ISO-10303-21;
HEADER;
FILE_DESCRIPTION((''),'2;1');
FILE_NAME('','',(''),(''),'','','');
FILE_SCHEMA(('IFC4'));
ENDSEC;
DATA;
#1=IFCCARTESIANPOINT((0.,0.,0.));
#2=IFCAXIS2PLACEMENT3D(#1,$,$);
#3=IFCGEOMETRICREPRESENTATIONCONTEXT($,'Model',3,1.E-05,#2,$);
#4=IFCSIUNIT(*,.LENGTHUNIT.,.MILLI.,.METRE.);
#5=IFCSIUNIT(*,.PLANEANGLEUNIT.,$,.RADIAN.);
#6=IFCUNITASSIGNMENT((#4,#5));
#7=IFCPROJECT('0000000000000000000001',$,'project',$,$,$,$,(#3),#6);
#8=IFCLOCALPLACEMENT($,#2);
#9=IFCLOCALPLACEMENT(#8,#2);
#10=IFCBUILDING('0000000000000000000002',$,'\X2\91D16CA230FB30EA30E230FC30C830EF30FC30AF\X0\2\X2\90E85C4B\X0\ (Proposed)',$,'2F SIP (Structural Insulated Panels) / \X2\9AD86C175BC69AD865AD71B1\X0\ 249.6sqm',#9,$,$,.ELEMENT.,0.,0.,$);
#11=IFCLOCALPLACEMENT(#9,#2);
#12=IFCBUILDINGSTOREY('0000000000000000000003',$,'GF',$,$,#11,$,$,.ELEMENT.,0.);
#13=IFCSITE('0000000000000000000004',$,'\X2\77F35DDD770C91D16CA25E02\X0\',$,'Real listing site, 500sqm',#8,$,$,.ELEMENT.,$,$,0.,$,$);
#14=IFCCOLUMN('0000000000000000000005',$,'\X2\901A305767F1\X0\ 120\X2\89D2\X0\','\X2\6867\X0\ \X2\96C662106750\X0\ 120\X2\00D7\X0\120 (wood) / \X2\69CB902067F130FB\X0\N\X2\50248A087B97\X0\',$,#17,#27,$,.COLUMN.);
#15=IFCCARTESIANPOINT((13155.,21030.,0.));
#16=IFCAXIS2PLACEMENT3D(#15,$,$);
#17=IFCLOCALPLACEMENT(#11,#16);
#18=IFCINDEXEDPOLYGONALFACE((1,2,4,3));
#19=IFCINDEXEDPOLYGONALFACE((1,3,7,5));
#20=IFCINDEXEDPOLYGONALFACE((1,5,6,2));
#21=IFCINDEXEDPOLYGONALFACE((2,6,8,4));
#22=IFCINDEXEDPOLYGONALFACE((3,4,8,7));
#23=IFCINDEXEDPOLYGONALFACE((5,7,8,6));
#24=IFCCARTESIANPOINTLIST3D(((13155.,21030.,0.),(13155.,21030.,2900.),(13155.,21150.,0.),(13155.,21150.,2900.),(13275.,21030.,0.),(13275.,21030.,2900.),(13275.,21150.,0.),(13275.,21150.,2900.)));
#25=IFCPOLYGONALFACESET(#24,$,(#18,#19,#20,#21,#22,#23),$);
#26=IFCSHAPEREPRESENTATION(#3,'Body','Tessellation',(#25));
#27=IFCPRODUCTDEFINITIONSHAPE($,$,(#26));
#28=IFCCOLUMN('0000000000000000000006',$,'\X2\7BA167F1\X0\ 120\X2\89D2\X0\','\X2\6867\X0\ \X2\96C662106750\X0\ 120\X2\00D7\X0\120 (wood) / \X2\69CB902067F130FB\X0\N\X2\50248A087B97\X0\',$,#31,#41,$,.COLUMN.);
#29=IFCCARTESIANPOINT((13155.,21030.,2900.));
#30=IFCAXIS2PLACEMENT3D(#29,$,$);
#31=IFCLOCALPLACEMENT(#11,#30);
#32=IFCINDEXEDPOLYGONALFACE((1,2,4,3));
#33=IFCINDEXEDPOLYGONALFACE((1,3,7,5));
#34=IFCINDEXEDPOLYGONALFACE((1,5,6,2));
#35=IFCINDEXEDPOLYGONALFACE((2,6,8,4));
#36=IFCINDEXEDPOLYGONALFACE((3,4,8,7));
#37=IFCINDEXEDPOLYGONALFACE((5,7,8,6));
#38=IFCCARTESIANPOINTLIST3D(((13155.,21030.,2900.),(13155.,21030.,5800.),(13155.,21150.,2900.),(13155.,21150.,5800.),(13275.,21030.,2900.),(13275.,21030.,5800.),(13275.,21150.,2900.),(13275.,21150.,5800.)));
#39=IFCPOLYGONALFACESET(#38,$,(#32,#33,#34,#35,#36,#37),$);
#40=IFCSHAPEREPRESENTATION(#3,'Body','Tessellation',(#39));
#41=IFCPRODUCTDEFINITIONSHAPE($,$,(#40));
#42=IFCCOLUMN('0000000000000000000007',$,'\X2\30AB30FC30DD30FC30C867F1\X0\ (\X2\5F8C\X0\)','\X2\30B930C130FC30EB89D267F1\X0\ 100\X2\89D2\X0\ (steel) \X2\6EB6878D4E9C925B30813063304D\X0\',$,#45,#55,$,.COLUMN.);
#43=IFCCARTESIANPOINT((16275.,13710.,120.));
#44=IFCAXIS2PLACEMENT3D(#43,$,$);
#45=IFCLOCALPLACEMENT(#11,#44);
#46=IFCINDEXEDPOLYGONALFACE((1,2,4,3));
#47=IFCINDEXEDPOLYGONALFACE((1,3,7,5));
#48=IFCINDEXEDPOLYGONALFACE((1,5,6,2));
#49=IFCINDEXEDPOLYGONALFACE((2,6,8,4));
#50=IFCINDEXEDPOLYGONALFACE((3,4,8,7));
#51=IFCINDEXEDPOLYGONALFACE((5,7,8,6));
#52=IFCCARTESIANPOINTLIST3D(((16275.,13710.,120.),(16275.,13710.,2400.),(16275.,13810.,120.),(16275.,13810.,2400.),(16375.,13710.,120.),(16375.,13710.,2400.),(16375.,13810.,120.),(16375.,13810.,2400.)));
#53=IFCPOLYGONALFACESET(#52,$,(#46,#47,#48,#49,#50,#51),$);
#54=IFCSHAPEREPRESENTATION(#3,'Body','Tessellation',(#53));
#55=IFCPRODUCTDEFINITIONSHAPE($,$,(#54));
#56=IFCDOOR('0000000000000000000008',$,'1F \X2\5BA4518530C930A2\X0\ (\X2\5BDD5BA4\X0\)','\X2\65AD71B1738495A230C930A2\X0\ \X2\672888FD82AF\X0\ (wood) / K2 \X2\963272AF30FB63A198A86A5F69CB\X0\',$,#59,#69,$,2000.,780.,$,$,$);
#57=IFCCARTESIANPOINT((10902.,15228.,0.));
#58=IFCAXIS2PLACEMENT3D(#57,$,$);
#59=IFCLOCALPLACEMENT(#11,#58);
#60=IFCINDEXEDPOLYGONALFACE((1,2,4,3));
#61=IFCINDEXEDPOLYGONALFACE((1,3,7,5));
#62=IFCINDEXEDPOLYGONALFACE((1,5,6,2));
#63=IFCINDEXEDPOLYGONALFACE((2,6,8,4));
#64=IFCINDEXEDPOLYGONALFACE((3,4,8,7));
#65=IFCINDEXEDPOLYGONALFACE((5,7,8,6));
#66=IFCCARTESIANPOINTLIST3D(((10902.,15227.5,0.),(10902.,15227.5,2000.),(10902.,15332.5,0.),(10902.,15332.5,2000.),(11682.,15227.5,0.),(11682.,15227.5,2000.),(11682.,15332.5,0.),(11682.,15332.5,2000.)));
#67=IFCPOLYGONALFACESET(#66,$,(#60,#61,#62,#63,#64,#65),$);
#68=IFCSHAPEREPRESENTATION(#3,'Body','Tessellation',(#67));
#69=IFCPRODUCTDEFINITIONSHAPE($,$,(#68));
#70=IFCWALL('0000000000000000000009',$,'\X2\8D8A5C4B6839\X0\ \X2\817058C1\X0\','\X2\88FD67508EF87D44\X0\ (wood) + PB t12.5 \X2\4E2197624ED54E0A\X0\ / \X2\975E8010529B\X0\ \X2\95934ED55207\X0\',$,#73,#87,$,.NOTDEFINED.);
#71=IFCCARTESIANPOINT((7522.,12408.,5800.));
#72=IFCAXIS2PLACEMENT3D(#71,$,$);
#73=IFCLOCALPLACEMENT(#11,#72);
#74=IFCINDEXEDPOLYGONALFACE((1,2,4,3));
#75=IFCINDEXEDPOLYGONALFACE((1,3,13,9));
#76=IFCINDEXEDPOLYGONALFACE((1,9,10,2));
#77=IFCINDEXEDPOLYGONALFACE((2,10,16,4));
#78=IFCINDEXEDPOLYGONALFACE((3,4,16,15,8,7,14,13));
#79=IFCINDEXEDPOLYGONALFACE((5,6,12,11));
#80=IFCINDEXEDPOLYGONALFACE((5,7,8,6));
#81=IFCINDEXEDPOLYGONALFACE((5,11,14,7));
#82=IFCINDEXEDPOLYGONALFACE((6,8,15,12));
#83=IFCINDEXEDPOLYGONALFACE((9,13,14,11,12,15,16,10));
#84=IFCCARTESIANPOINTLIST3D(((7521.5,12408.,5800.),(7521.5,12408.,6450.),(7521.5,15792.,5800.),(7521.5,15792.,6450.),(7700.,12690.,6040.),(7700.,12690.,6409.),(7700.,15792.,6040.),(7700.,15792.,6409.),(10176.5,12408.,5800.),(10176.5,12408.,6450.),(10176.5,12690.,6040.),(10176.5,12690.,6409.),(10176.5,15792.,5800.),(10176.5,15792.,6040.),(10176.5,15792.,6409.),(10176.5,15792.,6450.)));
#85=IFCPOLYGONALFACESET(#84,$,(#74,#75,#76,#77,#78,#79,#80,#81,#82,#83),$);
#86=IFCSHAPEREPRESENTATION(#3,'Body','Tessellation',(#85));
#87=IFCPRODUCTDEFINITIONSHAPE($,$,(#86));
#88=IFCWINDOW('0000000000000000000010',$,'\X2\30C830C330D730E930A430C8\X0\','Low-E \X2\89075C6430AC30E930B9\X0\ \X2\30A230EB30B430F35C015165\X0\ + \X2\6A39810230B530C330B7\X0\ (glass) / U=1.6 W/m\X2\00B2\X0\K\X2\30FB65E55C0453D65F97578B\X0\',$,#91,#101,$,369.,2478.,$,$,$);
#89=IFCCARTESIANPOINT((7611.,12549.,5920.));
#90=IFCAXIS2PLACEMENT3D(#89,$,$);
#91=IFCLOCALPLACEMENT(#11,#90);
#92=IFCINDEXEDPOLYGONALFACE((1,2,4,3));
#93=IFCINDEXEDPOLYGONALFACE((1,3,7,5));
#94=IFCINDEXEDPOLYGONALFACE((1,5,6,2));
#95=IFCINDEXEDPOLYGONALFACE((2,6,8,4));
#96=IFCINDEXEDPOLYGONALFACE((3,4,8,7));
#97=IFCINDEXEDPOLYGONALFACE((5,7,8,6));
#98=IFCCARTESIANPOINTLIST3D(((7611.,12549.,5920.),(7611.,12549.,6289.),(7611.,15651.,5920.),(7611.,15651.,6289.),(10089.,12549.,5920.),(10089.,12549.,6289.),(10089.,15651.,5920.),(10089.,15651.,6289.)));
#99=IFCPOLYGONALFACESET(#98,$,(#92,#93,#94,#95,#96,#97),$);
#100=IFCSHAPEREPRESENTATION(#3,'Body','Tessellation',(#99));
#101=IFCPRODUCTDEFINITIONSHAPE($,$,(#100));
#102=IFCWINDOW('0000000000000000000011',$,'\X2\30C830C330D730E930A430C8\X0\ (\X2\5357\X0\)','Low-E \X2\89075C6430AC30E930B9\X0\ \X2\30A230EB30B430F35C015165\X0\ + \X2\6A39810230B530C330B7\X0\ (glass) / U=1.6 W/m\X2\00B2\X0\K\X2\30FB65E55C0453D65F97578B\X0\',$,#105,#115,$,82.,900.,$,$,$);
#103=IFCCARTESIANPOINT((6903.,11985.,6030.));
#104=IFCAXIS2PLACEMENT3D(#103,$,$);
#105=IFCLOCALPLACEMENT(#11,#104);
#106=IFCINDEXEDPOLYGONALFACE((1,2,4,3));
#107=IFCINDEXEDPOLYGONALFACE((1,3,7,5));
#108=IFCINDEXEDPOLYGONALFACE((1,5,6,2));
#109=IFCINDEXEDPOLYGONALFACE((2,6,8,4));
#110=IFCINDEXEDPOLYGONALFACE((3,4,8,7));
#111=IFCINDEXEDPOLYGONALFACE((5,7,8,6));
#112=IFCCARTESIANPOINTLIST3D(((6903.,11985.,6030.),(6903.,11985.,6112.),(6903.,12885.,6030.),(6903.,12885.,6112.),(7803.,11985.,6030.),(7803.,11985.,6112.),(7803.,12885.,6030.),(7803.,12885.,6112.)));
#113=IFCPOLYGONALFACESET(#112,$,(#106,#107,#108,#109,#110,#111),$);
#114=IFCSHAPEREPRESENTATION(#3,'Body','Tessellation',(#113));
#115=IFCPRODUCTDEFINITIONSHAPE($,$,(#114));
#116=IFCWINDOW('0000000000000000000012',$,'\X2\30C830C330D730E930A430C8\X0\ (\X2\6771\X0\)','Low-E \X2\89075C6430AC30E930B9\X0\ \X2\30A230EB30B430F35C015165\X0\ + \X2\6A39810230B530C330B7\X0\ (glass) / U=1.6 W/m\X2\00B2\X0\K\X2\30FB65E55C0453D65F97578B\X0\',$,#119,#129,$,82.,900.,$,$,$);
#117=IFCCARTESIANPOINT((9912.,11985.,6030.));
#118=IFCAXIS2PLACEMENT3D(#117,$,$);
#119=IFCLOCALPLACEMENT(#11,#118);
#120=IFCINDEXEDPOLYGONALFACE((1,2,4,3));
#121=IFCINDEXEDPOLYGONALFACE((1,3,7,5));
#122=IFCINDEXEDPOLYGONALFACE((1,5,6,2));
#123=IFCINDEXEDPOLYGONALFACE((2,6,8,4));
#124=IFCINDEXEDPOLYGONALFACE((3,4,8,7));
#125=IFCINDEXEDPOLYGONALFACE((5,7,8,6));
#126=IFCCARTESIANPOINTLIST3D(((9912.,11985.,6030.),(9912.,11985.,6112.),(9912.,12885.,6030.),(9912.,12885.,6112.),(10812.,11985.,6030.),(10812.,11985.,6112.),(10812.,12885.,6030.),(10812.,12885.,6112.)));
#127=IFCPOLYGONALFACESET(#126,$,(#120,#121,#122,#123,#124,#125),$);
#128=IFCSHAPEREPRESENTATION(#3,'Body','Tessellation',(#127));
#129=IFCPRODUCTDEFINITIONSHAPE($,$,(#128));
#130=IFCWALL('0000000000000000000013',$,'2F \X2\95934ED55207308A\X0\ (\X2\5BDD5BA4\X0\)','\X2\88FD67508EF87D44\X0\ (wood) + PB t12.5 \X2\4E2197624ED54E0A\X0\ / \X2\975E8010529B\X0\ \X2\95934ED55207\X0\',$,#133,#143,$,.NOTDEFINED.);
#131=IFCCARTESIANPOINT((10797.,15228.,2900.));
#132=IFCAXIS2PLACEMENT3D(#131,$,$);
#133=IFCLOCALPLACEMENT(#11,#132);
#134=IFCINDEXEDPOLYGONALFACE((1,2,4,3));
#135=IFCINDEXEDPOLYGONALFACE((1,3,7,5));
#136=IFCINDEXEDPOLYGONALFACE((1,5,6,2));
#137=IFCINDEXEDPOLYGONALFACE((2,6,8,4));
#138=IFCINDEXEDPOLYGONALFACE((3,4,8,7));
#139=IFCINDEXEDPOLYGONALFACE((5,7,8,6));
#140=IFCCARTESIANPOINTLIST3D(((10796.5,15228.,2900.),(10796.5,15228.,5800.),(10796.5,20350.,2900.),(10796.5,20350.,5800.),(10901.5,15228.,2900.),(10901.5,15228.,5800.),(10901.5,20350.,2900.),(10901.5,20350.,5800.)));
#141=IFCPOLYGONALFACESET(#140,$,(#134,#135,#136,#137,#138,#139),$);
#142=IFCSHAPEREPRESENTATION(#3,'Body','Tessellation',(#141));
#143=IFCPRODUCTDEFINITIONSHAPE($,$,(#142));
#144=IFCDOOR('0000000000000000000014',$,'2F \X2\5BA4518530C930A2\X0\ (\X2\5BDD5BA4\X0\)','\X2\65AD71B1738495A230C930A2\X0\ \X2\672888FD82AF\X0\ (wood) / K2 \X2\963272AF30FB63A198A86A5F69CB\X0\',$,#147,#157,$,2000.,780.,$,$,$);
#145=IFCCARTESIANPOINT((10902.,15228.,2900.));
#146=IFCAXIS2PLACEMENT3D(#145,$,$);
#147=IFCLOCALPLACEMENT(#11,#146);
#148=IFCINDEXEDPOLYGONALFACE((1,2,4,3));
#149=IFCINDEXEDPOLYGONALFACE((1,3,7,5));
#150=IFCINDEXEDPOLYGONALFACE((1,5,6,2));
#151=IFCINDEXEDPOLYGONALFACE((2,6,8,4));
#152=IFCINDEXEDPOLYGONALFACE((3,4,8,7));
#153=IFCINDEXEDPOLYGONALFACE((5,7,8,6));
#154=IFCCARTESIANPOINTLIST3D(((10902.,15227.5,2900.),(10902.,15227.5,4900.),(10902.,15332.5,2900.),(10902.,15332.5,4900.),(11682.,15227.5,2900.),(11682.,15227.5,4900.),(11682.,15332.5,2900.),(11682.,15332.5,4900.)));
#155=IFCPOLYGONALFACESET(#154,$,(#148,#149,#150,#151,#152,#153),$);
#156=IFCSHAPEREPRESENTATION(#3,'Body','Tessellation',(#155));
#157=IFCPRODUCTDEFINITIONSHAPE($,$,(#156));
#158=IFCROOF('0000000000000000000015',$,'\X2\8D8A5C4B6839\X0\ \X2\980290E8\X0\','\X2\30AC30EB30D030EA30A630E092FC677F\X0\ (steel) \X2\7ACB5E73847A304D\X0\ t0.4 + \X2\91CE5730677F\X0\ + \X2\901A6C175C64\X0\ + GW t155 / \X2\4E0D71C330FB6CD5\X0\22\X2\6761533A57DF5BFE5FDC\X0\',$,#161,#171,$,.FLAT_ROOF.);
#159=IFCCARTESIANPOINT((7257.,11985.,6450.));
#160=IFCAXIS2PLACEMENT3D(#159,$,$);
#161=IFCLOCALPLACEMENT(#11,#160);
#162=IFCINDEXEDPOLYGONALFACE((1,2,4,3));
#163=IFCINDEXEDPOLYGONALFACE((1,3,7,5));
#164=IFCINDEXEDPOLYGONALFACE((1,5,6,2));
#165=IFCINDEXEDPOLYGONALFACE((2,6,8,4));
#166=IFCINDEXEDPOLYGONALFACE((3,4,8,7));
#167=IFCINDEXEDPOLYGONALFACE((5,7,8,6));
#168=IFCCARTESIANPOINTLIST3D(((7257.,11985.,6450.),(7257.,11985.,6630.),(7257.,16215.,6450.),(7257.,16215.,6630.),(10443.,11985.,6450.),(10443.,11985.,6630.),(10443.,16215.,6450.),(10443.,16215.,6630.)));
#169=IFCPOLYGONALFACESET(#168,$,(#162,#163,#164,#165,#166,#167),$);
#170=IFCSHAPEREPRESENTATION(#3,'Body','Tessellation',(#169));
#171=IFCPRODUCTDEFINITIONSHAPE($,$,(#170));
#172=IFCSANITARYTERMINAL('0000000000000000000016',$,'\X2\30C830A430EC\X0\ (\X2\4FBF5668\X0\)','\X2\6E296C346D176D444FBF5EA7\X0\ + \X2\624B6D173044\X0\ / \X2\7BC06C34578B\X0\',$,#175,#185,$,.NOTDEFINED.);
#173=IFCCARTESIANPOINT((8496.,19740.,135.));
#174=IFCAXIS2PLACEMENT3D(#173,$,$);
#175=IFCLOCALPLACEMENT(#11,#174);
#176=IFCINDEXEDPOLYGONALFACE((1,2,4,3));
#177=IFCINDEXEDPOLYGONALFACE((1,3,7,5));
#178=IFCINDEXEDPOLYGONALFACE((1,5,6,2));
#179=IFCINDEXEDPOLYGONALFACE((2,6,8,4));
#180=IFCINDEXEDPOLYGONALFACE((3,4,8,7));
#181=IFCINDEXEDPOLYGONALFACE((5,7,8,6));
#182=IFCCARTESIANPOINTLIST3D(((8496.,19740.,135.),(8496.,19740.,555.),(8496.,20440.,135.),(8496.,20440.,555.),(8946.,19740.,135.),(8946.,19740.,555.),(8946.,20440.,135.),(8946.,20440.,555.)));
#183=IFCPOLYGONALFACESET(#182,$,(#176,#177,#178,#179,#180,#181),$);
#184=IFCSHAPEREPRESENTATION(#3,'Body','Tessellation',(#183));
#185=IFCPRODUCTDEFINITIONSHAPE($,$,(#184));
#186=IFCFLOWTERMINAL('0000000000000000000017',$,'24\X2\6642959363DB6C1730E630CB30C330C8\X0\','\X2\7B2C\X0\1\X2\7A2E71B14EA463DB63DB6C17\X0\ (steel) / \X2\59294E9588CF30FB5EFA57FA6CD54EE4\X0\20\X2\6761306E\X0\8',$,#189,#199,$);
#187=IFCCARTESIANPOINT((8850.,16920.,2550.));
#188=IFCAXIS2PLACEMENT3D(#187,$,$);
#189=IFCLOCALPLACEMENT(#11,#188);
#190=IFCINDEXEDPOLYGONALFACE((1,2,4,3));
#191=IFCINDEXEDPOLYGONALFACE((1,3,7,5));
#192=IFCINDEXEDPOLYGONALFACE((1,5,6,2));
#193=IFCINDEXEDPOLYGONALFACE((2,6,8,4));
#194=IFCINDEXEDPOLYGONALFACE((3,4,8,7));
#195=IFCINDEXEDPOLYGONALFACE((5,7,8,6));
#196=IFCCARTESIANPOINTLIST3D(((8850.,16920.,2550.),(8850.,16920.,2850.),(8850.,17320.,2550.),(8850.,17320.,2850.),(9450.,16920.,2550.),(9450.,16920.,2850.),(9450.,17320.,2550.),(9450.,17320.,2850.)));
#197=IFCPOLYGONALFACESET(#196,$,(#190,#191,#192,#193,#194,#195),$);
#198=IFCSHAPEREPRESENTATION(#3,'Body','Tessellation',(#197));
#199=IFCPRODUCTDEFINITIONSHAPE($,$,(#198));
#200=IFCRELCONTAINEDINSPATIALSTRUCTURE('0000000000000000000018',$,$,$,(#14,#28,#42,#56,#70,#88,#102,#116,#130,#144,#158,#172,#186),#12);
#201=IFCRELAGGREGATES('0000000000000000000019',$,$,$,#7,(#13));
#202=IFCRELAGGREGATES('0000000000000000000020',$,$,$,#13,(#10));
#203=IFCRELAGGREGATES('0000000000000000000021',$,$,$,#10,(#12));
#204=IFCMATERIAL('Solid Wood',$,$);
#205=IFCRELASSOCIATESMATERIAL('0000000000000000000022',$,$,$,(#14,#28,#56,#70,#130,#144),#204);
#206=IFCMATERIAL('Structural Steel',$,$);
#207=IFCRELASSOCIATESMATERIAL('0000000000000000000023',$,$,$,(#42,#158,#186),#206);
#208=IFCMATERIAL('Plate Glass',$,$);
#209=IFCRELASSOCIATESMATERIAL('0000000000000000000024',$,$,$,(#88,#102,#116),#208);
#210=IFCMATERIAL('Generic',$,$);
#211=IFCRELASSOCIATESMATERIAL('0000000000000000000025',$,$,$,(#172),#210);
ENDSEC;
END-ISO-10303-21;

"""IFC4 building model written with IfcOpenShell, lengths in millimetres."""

from ifc_helpers import new_model, si_unit, frame, frame_2d, origin, place, context, project, spatial, rectangle, extrude, material, element, fill, save


model = new_model("IFC4")

# Units and contexts
model_context = context("Model", 3, precision=1e-05, world=origin())
ifc_project = project(units=[si_unit("LENGTHUNIT", "METRE", prefix="MILLI"), si_unit("PLANEANGLEUNIT", "RADIAN")], contexts=[model_context])

# Site, building, storey
site_placement = place(None, origin())
site = spatial("IfcSite", under=ifc_project, at=site_placement, Name="石川県金沢市", ObjectType="Real listing site, 500sqm", CompositionType="ELEMENT", RefElevation=0.0)
building_placement = place(site_placement, origin())
building = spatial("IfcBuilding", under=site, at=building_placement, Name="金沢・リモートワーク2部屋 (Proposed)", ObjectType="2F SIP (Structural Insulated Panels) / 高気密高断熱 249.6sqm", CompositionType="ELEMENT", ElevationOfRefHeight=0.0, ElevationOfTerrain=0.0)
storey_placement = place(building_placement, origin())
storey = spatial("IfcBuildingStorey", under=building, at=storey_placement, Name="GF", CompositionType="ELEMENT", Elevation=0.0)

# Columns
ifc_material_1 = material(Name="Solid Wood")
column_1_placement = place(storey_placement, frame((13155.0, 21030.0, 0.0)))
element("IfcColumn", 1, at=column_1_placement, inside=storey, material=ifc_material_1, Name="通し柱 120角", Description="桧 集成材 120×120 (wood) / 構造柱・N値計算", PredefinedType="COLUMN", context=model_context, shape_type="SweptSolid", body=[
    extrude(rectangle(XDim=120.0, YDim=120.0, at=frame_2d((60.0, 60.0))), frame((13155.0, 21030.0, 0.0)), (0.0, 0.0, 1.0), 2900.0),
])
column_2_placement = place(storey_placement, frame((13155.0, 21030.0, 2900.0)))
element("IfcColumn", 2, at=column_2_placement, inside=storey, material=ifc_material_1, Name="管柱 120角", Description="桧 集成材 120×120 (wood) / 構造柱・N値計算", PredefinedType="COLUMN", context=model_context, shape_type="SweptSolid", body=[
    extrude(rectangle(XDim=120.0, YDim=120.0, at=frame_2d((60.0, 60.0))), frame((13155.0, 21030.0, 2900.0)), (0.0, 0.0, 1.0), 2900.0),
])
ifc_material_2 = material(Name="Structural Steel")
column_3_placement = place(storey_placement, frame((16275.0, 13710.0, 120.0)))
element("IfcColumn", 3, at=column_3_placement, inside=storey, material=ifc_material_2, Name="カーポート柱 (後)", Description="スチール角柱 100角 (steel) 溶融亜鉛めっき", PredefinedType="COLUMN", context=model_context, shape_type="SweptSolid", body=[
    extrude(rectangle(XDim=100.0, YDim=100.0, at=frame_2d((50.0, 50.0))), frame((16275.0, 13710.0, 120.0)), (0.0, 0.0, 1.0), 2280.0),
])

# Door
door_1_placement = place(storey_placement, frame((10902.0, 15228.0, 0.0)))
element("IfcDoor", 4, at=door_1_placement, inside=storey, material=ifc_material_1, Name="1F 室内ドア (寝室)", Description="断熱玄関ドア 木製芯 (wood) / K2 防犯・採風機構", OverallHeight=2000.0, OverallWidth=780.0, context=model_context, shape_type="SweptSolid", body=[
    extrude(rectangle(XDim=780.0, YDim=105.0, at=frame_2d((390.0, 52.0))), frame((10902.0, 15228.0, 0.0)), (0.0, 0.0, 1.0), 2000.0),
])

# Wall, openings, windows
wall_1_placement = place(storey_placement, frame((7522.0, 12408.0, 5800.0)))
wall_1 = element("IfcWall", 5, at=wall_1_placement, inside=storey, material=ifc_material_1, Name="越屋根 腰壁", Description="製材軸組 (wood) + PB t12.5 両面仕上 / 非耐力 間仕切", PredefinedType="NOTDEFINED", context=model_context, shape_type="SweptSolid", body=[
    extrude(rectangle(XDim=2655.0, YDim=3384.0, at=frame_2d((1327.0, 1692.0))), frame((7522.0, 12408.0, 5800.0)), (0.0, 0.0, 1.0), 650.0),
])
opening_1_placement = place(storey_placement, frame((7611.0, 12549.0, 5920.0)))
opening_1 = element("IfcOpeningElement", 6, at=opening_1_placement, cuts=wall_1, PredefinedType="NOTDEFINED", context=model_context, shape_type="SweptSolid", body=[
    extrude(rectangle(XDim=2478.0, YDim=3102.0, at=frame_2d((1239.0, 1551.0))), frame((7611.0, 12549.0, 5920.0)), (0.0, 0.0, 1.0), 369.0),
])
opening_2_placement = place(storey_placement, frame((6903.0, 11985.0, 6030.0)))
opening_2 = element("IfcOpeningElement", 7, at=opening_2_placement, cuts=wall_1, PredefinedType="NOTDEFINED", context=model_context, shape_type="SweptSolid", body=[
    extrude(rectangle(XDim=900.0, YDim=900.0, at=frame_2d((450.0, 450.0))), frame((6903.0, 11985.0, 6030.0)), (0.0, 0.0, 1.0), 82.0),
])
opening_3_placement = place(storey_placement, frame((9912.0, 11985.0, 6030.0)))
opening_3 = element("IfcOpeningElement", 8, at=opening_3_placement, cuts=wall_1, PredefinedType="NOTDEFINED", context=model_context, shape_type="SweptSolid", body=[
    extrude(rectangle(XDim=900.0, YDim=900.0, at=frame_2d((450.0, 450.0))), frame((9912.0, 11985.0, 6030.0)), (0.0, 0.0, 1.0), 82.0),
])
ifc_material_3 = material(Name="Plate Glass")
window_1_placement = place(storey_placement, frame((7611.0, 12549.0, 5920.0)))
window_1 = element("IfcWindow", 9, at=window_1_placement, inside=storey, material=ifc_material_3, Name="トップライト", Description="Low-E 複層ガラス アルゴン封入 + 樹脂サッシ (glass) / U=1.6 W/m²K・日射取得型", OverallHeight=369.0, OverallWidth=2478.0, context=model_context, shape_type="SweptSolid", body=[
    extrude(rectangle(XDim=2478.0, YDim=3102.0, at=frame_2d((1239.0, 1551.0))), frame((7611.0, 12549.0, 5920.0)), (0.0, 0.0, 1.0), 369.0),
])
fill(opening_1, window_1)
window_2_placement = place(storey_placement, frame((6903.0, 11985.0, 6030.0)))
window_2 = element("IfcWindow", 10, at=window_2_placement, inside=storey, material=ifc_material_3, Name="トップライト (南)", Description="Low-E 複層ガラス アルゴン封入 + 樹脂サッシ (glass) / U=1.6 W/m²K・日射取得型", OverallHeight=82.0, OverallWidth=900.0, context=model_context, shape_type="SweptSolid", body=[
    extrude(rectangle(XDim=900.0, YDim=900.0, at=frame_2d((450.0, 450.0))), frame((6903.0, 11985.0, 6030.0)), (0.0, 0.0, 1.0), 82.0),
])
fill(opening_2, window_2)
window_3_placement = place(storey_placement, frame((9912.0, 11985.0, 6030.0)))
window_3 = element("IfcWindow", 11, at=window_3_placement, inside=storey, material=ifc_material_3, Name="トップライト (東)", Description="Low-E 複層ガラス アルゴン封入 + 樹脂サッシ (glass) / U=1.6 W/m²K・日射取得型", OverallHeight=82.0, OverallWidth=900.0, context=model_context, shape_type="SweptSolid", body=[
    extrude(rectangle(XDim=900.0, YDim=900.0, at=frame_2d((450.0, 450.0))), frame((9912.0, 11985.0, 6030.0)), (0.0, 0.0, 1.0), 82.0),
])
fill(opening_3, window_3)

# Wall
wall_2_placement = place(storey_placement, frame((10797.0, 15228.0, 2900.0)))
element("IfcWall", 12, at=wall_2_placement, inside=storey, material=ifc_material_1, Name="2F 間仕切り (寝室)", Description="製材軸組 (wood) + PB t12.5 両面仕上 / 非耐力 間仕切", PredefinedType="NOTDEFINED", context=model_context, shape_type="SweptSolid", body=[
    extrude(rectangle(XDim=105.0, YDim=5122.0, at=frame_2d((52.0, 2561.0))), frame((10797.0, 15228.0, 2900.0)), (0.0, 0.0, 1.0), 2900.0),
])

# Door
door_2_placement = place(storey_placement, frame((10902.0, 15228.0, 2900.0)))
element("IfcDoor", 13, at=door_2_placement, inside=storey, material=ifc_material_1, Name="2F 室内ドア (寝室)", Description="断熱玄関ドア 木製芯 (wood) / K2 防犯・採風機構", OverallHeight=2000.0, OverallWidth=780.0, context=model_context, shape_type="SweptSolid", body=[
    extrude(rectangle(XDim=780.0, YDim=105.0, at=frame_2d((390.0, 52.0))), frame((10902.0, 15228.0, 2900.0)), (0.0, 0.0, 1.0), 2000.0),
])

# Roof
roof_placement = place(storey_placement, frame((7257.0, 11985.0, 6450.0)))
element("IfcRoof", 14, at=roof_placement, inside=storey, material=ifc_material_2, Name="越屋根 頂部", Description="ガルバリウム鋼板 (steel) 立平葺き t0.4 + 野地板 + 通気層 + GW t155 / 不燃・法22条区域対応", PredefinedType="FLAT_ROOF", context=model_context, shape_type="SweptSolid", body=[
    extrude(rectangle(XDim=3186.0, YDim=4230.0, at=frame_2d((1593.0, 2115.0))), frame((7257.0, 11985.0, 6450.0)), (0.0, 0.0, 1.0), 180.0),
])

# Sanitary terminal
ifc_material_4 = material(Name="Generic")
sanitary_terminal_placement = place(storey_placement, frame((8496.0, 19740.0, 135.0)))
element("IfcSanitaryTerminal", 15, at=sanitary_terminal_placement, inside=storey, material=ifc_material_4, Name="トイレ (便器)", Description="温水洗浄便座 + 手洗い / 節水型", PredefinedType="NOTDEFINED", context=model_context, shape_type="SweptSolid", body=[
    extrude(rectangle(XDim=450.0, YDim=700.0, at=frame_2d((225.0, 350.0))), frame((8496.0, 19740.0, 135.0)), (0.0, 0.0, 1.0), 420.0),
])

# Flow terminal
flow_terminal_placement = place(storey_placement, frame((8850.0, 16920.0, 2550.0)))
element("IfcFlowTerminal", 16, at=flow_terminal_placement, inside=storey, material=ifc_material_2, Name="24時間換気ユニット", Description="第1種熱交換換気 (steel) / 天井裏・建基法令20条の8", context=model_context, shape_type="SweptSolid", body=[
    extrude(rectangle(XDim=600.0, YDim=400.0, at=frame_2d((300.0, 200.0))), frame((8850.0, 16920.0, 2550.0)), (0.0, 0.0, 1.0), 300.0),
])

save(model, "model.ifc")
